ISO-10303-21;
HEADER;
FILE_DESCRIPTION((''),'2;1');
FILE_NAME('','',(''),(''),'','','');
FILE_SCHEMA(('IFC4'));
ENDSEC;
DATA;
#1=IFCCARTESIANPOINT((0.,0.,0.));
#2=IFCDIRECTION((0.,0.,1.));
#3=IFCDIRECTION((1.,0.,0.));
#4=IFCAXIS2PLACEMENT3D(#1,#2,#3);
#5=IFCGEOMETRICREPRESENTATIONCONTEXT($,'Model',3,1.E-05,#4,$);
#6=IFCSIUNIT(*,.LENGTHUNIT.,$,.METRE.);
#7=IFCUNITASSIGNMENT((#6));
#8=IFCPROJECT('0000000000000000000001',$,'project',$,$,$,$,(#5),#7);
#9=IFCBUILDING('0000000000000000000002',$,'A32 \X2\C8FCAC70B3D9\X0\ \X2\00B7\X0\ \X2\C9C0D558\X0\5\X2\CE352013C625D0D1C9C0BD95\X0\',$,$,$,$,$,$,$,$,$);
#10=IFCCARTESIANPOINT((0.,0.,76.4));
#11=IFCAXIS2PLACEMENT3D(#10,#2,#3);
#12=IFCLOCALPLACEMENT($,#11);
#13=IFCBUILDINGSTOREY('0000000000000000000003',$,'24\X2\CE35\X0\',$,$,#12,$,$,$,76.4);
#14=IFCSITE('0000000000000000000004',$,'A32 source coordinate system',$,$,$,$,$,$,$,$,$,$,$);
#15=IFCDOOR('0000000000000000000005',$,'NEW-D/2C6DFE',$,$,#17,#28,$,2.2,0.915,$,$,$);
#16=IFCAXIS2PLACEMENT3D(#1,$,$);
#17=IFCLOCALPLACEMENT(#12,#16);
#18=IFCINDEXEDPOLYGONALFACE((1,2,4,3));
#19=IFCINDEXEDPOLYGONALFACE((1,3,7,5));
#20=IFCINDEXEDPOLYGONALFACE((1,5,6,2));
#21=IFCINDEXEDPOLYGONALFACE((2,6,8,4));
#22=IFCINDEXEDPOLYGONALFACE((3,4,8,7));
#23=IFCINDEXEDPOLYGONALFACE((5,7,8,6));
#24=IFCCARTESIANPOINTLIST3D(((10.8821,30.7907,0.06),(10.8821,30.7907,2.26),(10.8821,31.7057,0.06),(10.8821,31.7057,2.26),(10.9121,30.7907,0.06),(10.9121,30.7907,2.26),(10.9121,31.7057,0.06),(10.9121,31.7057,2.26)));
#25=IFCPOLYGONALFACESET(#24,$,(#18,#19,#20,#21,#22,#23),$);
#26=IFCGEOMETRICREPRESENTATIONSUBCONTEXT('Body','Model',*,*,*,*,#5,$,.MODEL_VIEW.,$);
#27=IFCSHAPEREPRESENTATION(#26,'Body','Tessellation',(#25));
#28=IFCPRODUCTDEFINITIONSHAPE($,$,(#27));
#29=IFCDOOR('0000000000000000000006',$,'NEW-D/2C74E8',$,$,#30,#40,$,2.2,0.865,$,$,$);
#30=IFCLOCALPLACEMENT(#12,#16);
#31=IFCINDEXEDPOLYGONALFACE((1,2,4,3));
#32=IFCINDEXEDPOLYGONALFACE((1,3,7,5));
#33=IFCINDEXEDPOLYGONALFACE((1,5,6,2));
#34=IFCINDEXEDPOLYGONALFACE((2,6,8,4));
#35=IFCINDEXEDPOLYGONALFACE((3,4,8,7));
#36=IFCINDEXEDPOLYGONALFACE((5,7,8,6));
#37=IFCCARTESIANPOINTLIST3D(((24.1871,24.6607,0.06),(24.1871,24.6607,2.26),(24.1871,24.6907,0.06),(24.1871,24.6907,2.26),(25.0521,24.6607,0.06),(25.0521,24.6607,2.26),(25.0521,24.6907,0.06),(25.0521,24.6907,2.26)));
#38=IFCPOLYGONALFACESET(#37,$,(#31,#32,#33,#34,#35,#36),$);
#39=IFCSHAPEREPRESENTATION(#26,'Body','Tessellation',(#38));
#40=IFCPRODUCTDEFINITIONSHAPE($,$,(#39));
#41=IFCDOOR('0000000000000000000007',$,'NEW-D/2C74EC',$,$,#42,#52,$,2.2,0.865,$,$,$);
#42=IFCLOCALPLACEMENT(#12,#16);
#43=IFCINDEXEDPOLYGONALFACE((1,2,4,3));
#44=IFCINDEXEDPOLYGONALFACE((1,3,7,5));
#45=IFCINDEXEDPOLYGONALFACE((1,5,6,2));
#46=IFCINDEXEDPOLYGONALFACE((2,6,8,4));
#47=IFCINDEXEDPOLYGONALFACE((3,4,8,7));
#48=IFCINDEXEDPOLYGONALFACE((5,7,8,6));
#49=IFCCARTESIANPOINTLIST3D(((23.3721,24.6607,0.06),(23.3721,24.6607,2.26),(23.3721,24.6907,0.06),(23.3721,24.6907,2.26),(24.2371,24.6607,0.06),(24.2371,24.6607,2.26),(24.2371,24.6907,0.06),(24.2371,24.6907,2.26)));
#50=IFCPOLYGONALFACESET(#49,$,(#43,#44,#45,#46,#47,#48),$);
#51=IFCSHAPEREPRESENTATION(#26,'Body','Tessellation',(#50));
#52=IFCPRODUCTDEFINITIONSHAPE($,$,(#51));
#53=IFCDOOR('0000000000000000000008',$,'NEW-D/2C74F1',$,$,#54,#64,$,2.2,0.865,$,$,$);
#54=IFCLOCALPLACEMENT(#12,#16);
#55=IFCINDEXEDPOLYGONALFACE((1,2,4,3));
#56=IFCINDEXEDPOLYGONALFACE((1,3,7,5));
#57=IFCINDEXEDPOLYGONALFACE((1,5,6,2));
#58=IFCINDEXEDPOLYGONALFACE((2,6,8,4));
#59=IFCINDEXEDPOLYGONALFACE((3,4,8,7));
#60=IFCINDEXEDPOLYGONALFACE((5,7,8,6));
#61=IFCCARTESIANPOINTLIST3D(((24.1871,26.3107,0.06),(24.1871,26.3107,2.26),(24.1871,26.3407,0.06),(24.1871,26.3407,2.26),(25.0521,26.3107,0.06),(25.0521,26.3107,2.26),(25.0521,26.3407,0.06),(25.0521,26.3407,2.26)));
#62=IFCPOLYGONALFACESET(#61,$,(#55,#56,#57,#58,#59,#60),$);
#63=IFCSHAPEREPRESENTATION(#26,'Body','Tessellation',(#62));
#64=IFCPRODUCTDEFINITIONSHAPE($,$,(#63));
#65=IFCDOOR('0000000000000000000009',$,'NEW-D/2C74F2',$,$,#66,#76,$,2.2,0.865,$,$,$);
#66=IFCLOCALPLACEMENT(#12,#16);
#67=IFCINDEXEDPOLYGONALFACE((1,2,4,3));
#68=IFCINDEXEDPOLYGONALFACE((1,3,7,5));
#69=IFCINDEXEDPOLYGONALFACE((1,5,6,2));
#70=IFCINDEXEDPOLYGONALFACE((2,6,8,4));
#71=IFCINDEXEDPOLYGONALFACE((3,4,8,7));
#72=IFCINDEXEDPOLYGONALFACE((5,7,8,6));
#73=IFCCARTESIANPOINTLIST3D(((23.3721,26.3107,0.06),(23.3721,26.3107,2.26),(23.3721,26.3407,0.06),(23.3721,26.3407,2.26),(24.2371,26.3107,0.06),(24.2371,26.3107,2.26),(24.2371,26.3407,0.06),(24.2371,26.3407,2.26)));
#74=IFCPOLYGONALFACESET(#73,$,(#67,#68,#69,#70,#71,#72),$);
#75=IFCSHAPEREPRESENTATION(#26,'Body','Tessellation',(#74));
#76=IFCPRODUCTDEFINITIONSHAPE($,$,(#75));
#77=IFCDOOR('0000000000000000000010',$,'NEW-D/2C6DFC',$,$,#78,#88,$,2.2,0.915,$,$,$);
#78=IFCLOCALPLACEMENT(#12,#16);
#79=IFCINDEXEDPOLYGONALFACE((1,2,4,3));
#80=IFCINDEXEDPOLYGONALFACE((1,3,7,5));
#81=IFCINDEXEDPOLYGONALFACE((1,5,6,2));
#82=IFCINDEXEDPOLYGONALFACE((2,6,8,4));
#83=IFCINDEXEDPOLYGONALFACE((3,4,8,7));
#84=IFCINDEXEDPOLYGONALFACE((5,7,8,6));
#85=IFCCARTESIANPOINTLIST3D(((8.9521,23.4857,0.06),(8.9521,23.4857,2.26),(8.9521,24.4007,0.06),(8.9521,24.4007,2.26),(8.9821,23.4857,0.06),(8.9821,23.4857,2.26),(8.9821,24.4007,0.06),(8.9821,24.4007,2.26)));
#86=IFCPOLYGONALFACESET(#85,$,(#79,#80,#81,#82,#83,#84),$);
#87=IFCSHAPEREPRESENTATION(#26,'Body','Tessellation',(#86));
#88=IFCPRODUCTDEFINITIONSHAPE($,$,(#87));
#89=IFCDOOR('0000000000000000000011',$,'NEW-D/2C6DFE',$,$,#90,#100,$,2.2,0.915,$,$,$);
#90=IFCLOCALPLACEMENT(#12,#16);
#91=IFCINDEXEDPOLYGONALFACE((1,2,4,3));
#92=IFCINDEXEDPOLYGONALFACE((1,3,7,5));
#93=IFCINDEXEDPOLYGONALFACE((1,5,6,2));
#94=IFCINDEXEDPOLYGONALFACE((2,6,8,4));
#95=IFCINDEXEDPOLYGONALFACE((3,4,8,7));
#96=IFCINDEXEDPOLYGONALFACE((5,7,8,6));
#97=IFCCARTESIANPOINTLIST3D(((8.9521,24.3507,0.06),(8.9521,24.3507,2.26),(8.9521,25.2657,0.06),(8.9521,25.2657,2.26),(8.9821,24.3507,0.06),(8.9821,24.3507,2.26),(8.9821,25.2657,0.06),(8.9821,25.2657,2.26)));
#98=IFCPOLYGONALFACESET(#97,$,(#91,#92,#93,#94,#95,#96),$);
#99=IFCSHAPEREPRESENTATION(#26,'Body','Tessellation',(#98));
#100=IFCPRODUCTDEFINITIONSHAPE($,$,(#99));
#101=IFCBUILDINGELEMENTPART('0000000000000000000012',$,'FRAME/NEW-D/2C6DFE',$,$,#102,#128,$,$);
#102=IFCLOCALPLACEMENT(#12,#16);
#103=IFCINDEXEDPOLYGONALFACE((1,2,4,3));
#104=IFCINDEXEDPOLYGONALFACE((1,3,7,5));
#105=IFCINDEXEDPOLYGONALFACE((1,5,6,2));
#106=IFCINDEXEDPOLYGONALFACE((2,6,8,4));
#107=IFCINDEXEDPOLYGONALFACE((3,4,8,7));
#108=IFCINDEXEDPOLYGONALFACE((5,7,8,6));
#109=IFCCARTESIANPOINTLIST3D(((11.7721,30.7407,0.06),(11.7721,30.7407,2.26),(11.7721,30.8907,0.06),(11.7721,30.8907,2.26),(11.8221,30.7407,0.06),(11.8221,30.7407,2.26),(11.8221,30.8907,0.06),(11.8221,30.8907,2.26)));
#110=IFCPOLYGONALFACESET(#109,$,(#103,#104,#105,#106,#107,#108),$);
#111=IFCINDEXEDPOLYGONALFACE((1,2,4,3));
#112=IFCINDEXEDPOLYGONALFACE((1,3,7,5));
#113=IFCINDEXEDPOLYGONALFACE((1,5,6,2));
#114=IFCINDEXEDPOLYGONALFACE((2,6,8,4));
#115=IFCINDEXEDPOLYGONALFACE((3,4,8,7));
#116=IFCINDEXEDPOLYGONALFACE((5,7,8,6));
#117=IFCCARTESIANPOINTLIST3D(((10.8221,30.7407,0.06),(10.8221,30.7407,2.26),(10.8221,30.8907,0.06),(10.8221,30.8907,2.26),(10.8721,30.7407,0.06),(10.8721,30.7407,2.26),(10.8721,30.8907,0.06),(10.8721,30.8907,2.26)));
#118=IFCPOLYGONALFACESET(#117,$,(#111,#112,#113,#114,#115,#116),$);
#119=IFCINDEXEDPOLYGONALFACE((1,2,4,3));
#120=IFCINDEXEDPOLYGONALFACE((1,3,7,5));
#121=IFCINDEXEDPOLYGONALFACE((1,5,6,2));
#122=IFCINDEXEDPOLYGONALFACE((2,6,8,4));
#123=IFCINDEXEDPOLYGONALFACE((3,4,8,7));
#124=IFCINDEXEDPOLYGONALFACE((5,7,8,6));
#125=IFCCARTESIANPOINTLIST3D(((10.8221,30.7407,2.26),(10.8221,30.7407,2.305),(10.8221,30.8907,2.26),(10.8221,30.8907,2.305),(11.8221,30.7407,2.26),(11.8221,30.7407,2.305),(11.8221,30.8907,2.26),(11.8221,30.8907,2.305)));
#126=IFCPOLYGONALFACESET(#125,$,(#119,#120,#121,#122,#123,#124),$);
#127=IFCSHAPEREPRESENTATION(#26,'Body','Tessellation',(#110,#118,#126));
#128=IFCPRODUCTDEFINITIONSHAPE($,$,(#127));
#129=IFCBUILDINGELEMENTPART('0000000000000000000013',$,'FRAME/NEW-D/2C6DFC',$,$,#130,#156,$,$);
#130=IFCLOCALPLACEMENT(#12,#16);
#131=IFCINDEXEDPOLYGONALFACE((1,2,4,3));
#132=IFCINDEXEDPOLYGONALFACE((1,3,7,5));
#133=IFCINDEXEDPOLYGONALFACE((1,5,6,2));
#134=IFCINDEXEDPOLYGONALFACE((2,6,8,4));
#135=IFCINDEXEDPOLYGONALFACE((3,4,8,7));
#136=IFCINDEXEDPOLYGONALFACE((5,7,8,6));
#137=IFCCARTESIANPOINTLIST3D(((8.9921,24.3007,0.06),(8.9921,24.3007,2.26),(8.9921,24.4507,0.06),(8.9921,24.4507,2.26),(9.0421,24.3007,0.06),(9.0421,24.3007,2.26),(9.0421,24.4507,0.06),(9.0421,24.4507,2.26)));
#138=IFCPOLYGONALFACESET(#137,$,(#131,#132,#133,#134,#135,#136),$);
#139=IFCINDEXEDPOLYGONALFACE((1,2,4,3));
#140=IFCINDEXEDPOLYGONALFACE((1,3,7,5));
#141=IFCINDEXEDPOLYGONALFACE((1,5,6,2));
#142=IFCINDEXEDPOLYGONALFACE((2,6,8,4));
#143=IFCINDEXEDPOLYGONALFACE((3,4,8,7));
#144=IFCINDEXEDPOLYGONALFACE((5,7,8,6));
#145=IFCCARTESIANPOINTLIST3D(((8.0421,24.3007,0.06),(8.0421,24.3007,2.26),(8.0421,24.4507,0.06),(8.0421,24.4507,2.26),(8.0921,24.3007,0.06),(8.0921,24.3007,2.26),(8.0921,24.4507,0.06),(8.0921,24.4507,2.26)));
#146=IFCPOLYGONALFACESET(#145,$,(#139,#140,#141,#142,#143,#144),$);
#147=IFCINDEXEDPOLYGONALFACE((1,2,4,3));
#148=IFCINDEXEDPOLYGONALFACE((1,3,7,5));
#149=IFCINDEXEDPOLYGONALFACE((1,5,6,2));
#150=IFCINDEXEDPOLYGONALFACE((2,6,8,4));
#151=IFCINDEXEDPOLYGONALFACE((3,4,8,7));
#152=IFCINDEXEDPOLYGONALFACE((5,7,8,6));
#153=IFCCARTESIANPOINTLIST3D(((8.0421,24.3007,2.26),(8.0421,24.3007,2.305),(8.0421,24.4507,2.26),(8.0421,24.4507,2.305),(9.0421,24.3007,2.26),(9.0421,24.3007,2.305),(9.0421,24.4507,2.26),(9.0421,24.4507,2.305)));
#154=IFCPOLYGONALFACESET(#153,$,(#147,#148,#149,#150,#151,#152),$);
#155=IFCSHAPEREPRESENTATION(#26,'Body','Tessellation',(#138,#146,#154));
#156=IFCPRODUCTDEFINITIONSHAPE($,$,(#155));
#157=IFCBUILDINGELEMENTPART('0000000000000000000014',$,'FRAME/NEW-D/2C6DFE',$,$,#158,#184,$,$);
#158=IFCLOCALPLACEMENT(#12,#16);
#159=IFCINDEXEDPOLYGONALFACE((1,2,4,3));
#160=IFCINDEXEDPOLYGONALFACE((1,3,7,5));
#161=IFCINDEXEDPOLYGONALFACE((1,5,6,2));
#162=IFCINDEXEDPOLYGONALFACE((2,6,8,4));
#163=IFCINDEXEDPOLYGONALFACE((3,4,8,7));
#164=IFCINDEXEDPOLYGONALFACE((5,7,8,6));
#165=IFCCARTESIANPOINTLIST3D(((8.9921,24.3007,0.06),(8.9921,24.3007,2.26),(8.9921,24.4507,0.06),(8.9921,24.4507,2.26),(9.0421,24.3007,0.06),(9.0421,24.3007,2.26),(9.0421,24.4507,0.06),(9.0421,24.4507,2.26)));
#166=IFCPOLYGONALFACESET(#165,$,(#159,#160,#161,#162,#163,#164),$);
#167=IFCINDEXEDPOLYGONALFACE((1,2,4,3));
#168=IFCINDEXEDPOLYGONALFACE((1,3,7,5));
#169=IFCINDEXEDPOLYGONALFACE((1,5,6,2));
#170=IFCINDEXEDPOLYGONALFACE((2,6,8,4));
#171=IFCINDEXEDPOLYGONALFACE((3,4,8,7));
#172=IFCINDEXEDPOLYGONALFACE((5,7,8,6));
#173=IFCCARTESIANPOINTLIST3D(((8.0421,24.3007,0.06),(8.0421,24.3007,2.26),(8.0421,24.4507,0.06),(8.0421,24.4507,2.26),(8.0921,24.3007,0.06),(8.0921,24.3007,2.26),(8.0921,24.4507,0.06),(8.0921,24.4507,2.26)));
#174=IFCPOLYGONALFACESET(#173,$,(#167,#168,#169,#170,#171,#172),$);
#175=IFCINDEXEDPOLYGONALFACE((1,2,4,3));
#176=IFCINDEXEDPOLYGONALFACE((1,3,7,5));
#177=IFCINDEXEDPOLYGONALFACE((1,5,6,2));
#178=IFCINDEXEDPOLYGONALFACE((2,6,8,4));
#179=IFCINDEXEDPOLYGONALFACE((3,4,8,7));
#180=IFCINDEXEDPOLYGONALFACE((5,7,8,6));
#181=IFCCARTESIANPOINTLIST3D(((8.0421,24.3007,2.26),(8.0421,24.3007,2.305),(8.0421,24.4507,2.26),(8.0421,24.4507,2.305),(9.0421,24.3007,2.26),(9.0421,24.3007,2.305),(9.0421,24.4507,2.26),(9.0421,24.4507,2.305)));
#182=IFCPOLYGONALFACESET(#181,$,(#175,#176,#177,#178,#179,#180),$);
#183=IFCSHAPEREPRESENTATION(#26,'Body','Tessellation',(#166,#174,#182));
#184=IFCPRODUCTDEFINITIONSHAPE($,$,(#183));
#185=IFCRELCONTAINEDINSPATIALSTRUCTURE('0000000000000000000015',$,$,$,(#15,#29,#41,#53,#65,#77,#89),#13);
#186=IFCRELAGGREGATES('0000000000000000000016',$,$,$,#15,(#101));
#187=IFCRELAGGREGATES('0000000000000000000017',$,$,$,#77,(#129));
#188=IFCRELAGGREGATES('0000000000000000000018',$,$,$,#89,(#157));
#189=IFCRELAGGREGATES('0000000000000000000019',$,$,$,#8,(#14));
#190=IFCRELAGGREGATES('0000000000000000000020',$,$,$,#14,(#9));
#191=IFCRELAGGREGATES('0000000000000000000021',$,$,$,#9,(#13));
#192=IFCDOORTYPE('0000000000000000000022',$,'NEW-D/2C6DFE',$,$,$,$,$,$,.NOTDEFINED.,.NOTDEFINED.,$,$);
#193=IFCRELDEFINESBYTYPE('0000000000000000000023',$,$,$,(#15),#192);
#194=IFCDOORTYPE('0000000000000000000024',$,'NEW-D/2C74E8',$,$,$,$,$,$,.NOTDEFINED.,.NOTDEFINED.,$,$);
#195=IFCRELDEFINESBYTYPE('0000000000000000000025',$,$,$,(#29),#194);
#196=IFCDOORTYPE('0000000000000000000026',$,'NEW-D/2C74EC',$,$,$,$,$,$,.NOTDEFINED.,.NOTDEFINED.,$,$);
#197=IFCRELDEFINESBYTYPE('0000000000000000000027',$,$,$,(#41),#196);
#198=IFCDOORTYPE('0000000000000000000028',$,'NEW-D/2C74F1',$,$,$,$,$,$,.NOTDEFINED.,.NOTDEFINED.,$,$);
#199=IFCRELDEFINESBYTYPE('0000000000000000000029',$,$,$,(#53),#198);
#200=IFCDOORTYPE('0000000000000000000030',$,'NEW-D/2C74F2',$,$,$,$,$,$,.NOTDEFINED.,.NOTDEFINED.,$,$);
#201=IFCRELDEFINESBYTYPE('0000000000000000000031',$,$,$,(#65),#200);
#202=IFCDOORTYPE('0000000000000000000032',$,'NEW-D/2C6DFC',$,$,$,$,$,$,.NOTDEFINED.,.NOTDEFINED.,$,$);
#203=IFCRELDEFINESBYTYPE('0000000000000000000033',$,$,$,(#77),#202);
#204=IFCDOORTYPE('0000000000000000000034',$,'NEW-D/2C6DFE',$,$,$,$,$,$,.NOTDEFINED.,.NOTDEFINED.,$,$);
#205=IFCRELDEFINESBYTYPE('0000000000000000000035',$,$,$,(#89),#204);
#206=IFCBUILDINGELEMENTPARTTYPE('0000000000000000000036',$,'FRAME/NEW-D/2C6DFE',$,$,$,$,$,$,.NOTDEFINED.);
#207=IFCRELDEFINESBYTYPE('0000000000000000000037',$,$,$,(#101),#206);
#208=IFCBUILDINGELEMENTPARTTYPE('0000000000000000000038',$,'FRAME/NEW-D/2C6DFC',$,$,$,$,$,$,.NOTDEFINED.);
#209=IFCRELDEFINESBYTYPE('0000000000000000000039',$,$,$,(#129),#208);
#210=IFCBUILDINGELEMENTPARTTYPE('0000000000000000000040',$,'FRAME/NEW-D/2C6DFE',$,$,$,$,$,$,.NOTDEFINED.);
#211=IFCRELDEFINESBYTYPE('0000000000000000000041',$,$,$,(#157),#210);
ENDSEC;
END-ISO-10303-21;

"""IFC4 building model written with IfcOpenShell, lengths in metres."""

from ifc_helpers import new_model, si_unit, frame, origin, origin_with_axes, place, context, subcontext, project, spatial, polyline, outline, extrude, source, transform, mapped, type_object, type_shapes, element, aggregate, save


model = new_model("IFC4")

# Units and contexts
model_context = context("Model", 3, precision=1e-05, world=origin_with_axes())
body_context = subcontext(model_context, "Body", "Model", "MODEL_VIEW")
ifc_project = project(units=[si_unit("LENGTHUNIT", "METRE")], contexts=[model_context])

# Site, building, storey
site = spatial("IfcSite", under=ifc_project, Name="A32 source coordinate system")
building = spatial("IfcBuilding", under=site, Name="A32 주거동 · 지하5층–옥탑지붕")
storey_placement = place(None, frame((0.0, 0.0, 76.4), z_axis=(0.0, 0.0, 1.0), x_axis=(1.0, 0.0, 0.0)))
storey = spatial("IfcBuildingStorey", under=building, at=storey_placement, Name="24층", Elevation=76.4)

# Door
door_type_1 = type_object("IfcDoorType", Name="NEW-D/2C6DFE", OperationType="NOTDEFINED", PredefinedType="NOTDEFINED")
shared_shape_1 = source(origin(), body_context, "Body", "SweptSolid", [
    extrude(outline(polyline([(10.8821, 31.7057), (10.9121, 31.7057), (10.9121, 30.7907), (10.8821, 30.7907), (10.8821, 31.7057)])), frame((0.0, 0.0, 0.06)), (0.0, 0.0, 1.0), 2.2),
])
type_shapes(door_type_1, [shared_shape_1])
door_1_placement = place(storey_placement, origin_with_axes())
door_1 = element("IfcDoor", 1, at=door_1_placement, inside=storey, type_object=door_type_1, Name="NEW-D/2C6DFE", OverallHeight=2.2, OverallWidth=0.915, context=body_context, shape_type="MappedRepresentation", body=[
    mapped(shared_shape_1, transform((0.0, 0.0, 0.0), scale=1.0)),
])

# Doors
door_type_2 = type_object("IfcDoorType", Name="NEW-D/2C74E8", OperationType="NOTDEFINED", PredefinedType="NOTDEFINED")
shared_shape_2 = source(origin(), body_context, "Body", "SweptSolid", [
    extrude(outline(polyline([(24.1871, 24.6907), (25.0521, 24.6907), (25.0521, 24.6607), (24.1871, 24.6607), (24.1871, 24.6907)])), frame((0.0, 0.0, 0.06)), (0.0, 0.0, 1.0), 2.2),
])
type_shapes(door_type_2, [shared_shape_2])
door_2_placement = place(storey_placement, origin_with_axes())
element("IfcDoor", 2, at=door_2_placement, inside=storey, type_object=door_type_2, Name="NEW-D/2C74E8", OverallHeight=2.2, OverallWidth=0.865, context=body_context, shape_type="MappedRepresentation", body=[
    mapped(shared_shape_2, transform((0.0, 0.0, 0.0), scale=1.0)),
])
door_type_3 = type_object("IfcDoorType", Name="NEW-D/2C74EC", OperationType="NOTDEFINED", PredefinedType="NOTDEFINED")
shared_shape_3 = source(origin(), body_context, "Body", "SweptSolid", [
    extrude(outline(polyline([(23.3721, 24.6607), (23.3721, 24.6907), (24.2371, 24.6907), (24.2371, 24.6607), (23.3721, 24.6607)])), frame((0.0, 0.0, 0.06)), (0.0, 0.0, 1.0), 2.2),
])
type_shapes(door_type_3, [shared_shape_3])
door_3_placement = place(storey_placement, origin_with_axes())
element("IfcDoor", 3, at=door_3_placement, inside=storey, type_object=door_type_3, Name="NEW-D/2C74EC", OverallHeight=2.2, OverallWidth=0.865, context=body_context, shape_type="MappedRepresentation", body=[
    mapped(shared_shape_3, transform((0.0, 0.0, 0.0), scale=1.0)),
])
door_type_4 = type_object("IfcDoorType", Name="NEW-D/2C74F1", OperationType="NOTDEFINED", PredefinedType="NOTDEFINED")
shared_shape_4 = source(origin(), body_context, "Body", "SweptSolid", [
    extrude(outline(polyline([(25.0521, 26.3407), (25.0521, 26.3107), (24.1871, 26.3107), (24.1871, 26.3407), (25.0521, 26.3407)])), frame((0.0, 0.0, 0.06)), (0.0, 0.0, 1.0), 2.2),
])
type_shapes(door_type_4, [shared_shape_4])
door_4_placement = place(storey_placement, origin_with_axes())
element("IfcDoor", 4, at=door_4_placement, inside=storey, type_object=door_type_4, Name="NEW-D/2C74F1", OverallHeight=2.2, OverallWidth=0.865, context=body_context, shape_type="MappedRepresentation", body=[
    mapped(shared_shape_4, transform((0.0, 0.0, 0.0), scale=1.0)),
])
door_type_5 = type_object("IfcDoorType", Name="NEW-D/2C74F2", OperationType="NOTDEFINED", PredefinedType="NOTDEFINED")
shared_shape_5 = source(origin(), body_context, "Body", "SweptSolid", [
    extrude(outline(polyline([(24.2371, 26.3107), (23.3721, 26.3107), (23.3721, 26.3407), (24.2371, 26.3407), (24.2371, 26.3107)])), frame((0.0, 0.0, 0.06)), (0.0, 0.0, 1.0), 2.2),
])
type_shapes(door_type_5, [shared_shape_5])
door_5_placement = place(storey_placement, origin_with_axes())
element("IfcDoor", 5, at=door_5_placement, inside=storey, type_object=door_type_5, Name="NEW-D/2C74F2", OverallHeight=2.2, OverallWidth=0.865, context=body_context, shape_type="MappedRepresentation", body=[
    mapped(shared_shape_5, transform((0.0, 0.0, 0.0), scale=1.0)),
])

# Doors
door_type_6 = type_object("IfcDoorType", Name="NEW-D/2C6DFC", OperationType="NOTDEFINED", PredefinedType="NOTDEFINED")
shared_shape_6 = source(origin(), body_context, "Body", "SweptSolid", [
    extrude(outline(polyline([(8.9821, 23.4857), (8.9521, 23.4857), (8.9521, 24.4007), (8.9821, 24.4007), (8.9821, 23.4857)])), frame((0.0, 0.0, 0.06)), (0.0, 0.0, 1.0), 2.2),
])
type_shapes(door_type_6, [shared_shape_6])
door_6_placement = place(storey_placement, origin_with_axes())
door_6 = element("IfcDoor", 6, at=door_6_placement, inside=storey, type_object=door_type_6, Name="NEW-D/2C6DFC", OverallHeight=2.2, OverallWidth=0.915, context=body_context, shape_type="MappedRepresentation", body=[
    mapped(shared_shape_6, transform((0.0, 0.0, 0.0), scale=1.0)),
])
door_type_7 = type_object("IfcDoorType", Name="NEW-D/2C6DFE", OperationType="NOTDEFINED", PredefinedType="NOTDEFINED")
shared_shape_7 = source(origin(), body_context, "Body", "SweptSolid", [
    extrude(outline(polyline([(8.9521, 24.3507), (8.9521, 25.2657), (8.9821, 25.2657), (8.9821, 24.3507), (8.9521, 24.3507)])), frame((0.0, 0.0, 0.06)), (0.0, 0.0, 1.0), 2.2),
])
type_shapes(door_type_7, [shared_shape_7])
door_7_placement = place(storey_placement, origin_with_axes())
door_7 = element("IfcDoor", 7, at=door_7_placement, inside=storey, type_object=door_type_7, Name="NEW-D/2C6DFE", OverallHeight=2.2, OverallWidth=0.915, context=body_context, shape_type="MappedRepresentation", body=[
    mapped(shared_shape_7, transform((0.0, 0.0, 0.0), scale=1.0)),
])

# Building element parts
building_element_part_type_1 = type_object("IfcBuildingElementPartType", Name="FRAME/NEW-D/2C6DFE", PredefinedType="NOTDEFINED")
shared_shape_8 = source(origin(), body_context, "Body", "SweptSolid", [
    extrude(outline(polyline([(11.8221, 30.8907), (11.8221, 30.7407), (11.7721, 30.7407), (11.7721, 30.8907), (11.8221, 30.8907)])), frame((0.0, 0.0, 0.06)), (0.0, 0.0, 1.0), 2.2),
    extrude(outline(polyline([(10.8721, 30.8907), (10.8721, 30.7407), (10.8221, 30.7407), (10.8221, 30.8907), (10.8721, 30.8907)])), frame((0.0, 0.0, 0.06)), (0.0, 0.0, 1.0), 2.2),
    extrude(outline(polyline([(11.8221, 30.7407), (11.8221, 30.8907), (10.8221, 30.8907), (10.8221, 30.7407), (11.8221, 30.7407)])), frame((0.0, 0.0, 2.26)), (0.0, 0.0, 1.0), 0.045),
])
type_shapes(building_element_part_type_1, [shared_shape_8])
building_element_part_1_placement = place(door_1_placement, origin_with_axes())
building_element_part_1 = element("IfcBuildingElementPart", 8, at=building_element_part_1_placement, type_object=building_element_part_type_1, Name="FRAME/NEW-D/2C6DFE", context=body_context, shape_type="MappedRepresentation", body=[
    mapped(shared_shape_8, transform((0.0, 0.0, 0.0), scale=1.0)),
])
aggregate(door_1, [building_element_part_1])
building_element_part_type_2 = type_object("IfcBuildingElementPartType", Name="FRAME/NEW-D/2C6DFC", PredefinedType="NOTDEFINED")
shared_shape_9 = source(origin(), body_context, "Body", "SweptSolid", [
    extrude(outline(polyline([(8.9921, 24.4507), (9.0421, 24.4507), (9.0421, 24.3007), (8.9921, 24.3007), (8.9921, 24.4507)])), frame((0.0, 0.0, 0.06)), (0.0, 0.0, 1.0), 2.2),
    extrude(outline(polyline([(8.0421, 24.4507), (8.0921, 24.4507), (8.0921, 24.3007), (8.0421, 24.3007), (8.0421, 24.4507)])), frame((0.0, 0.0, 0.06)), (0.0, 0.0, 1.0), 2.2),
    extrude(outline(polyline([(9.0421, 24.3007), (9.0421, 24.4507), (8.0421, 24.4507), (8.0421, 24.3007), (9.0421, 24.3007)])), frame((0.0, 0.0, 2.26)), (0.0, 0.0, 1.0), 0.045),
])
type_shapes(building_element_part_type_2, [shared_shape_9])
building_element_part_2_placement = place(door_6_placement, origin_with_axes())
building_element_part_2 = element("IfcBuildingElementPart", 9, at=building_element_part_2_placement, type_object=building_element_part_type_2, Name="FRAME/NEW-D/2C6DFC", context=body_context, shape_type="MappedRepresentation", body=[
    mapped(shared_shape_9, transform((0.0, 0.0, 0.0), scale=1.0)),
])
aggregate(door_6, [building_element_part_2])
building_element_part_type_3 = type_object("IfcBuildingElementPartType", Name="FRAME/NEW-D/2C6DFE", PredefinedType="NOTDEFINED")
shared_shape_10 = source(origin(), body_context, "Body", "SweptSolid", [
    extrude(outline(polyline([(8.9921, 24.4507), (9.0421, 24.4507), (9.0421, 24.3007), (8.9921, 24.3007), (8.9921, 24.4507)])), frame((0.0, 0.0, 0.06)), (0.0, 0.0, 1.0), 2.2),
    extrude(outline(polyline([(8.0421, 24.4507), (8.0921, 24.4507), (8.0921, 24.3007), (8.0421, 24.3007), (8.0421, 24.4507)])), frame((0.0, 0.0, 0.06)), (0.0, 0.0, 1.0), 2.2),
    extrude(outline(polyline([(9.0421, 24.3007), (9.0421, 24.4507), (8.0421, 24.4507), (8.0421, 24.3007), (9.0421, 24.3007)])), frame((0.0, 0.0, 2.26)), (0.0, 0.0, 1.0), 0.045),
])
type_shapes(building_element_part_type_3, [shared_shape_10])
building_element_part_3_placement = place(door_7_placement, origin_with_axes())
building_element_part_3 = element("IfcBuildingElementPart", 10, at=building_element_part_3_placement, type_object=building_element_part_type_3, Name="FRAME/NEW-D/2C6DFE", context=body_context, shape_type="MappedRepresentation", body=[
    mapped(shared_shape_10, transform((0.0, 0.0, 0.0), scale=1.0)),
])
aggregate(door_7, [building_element_part_3])

save(model, "model.ifc")
